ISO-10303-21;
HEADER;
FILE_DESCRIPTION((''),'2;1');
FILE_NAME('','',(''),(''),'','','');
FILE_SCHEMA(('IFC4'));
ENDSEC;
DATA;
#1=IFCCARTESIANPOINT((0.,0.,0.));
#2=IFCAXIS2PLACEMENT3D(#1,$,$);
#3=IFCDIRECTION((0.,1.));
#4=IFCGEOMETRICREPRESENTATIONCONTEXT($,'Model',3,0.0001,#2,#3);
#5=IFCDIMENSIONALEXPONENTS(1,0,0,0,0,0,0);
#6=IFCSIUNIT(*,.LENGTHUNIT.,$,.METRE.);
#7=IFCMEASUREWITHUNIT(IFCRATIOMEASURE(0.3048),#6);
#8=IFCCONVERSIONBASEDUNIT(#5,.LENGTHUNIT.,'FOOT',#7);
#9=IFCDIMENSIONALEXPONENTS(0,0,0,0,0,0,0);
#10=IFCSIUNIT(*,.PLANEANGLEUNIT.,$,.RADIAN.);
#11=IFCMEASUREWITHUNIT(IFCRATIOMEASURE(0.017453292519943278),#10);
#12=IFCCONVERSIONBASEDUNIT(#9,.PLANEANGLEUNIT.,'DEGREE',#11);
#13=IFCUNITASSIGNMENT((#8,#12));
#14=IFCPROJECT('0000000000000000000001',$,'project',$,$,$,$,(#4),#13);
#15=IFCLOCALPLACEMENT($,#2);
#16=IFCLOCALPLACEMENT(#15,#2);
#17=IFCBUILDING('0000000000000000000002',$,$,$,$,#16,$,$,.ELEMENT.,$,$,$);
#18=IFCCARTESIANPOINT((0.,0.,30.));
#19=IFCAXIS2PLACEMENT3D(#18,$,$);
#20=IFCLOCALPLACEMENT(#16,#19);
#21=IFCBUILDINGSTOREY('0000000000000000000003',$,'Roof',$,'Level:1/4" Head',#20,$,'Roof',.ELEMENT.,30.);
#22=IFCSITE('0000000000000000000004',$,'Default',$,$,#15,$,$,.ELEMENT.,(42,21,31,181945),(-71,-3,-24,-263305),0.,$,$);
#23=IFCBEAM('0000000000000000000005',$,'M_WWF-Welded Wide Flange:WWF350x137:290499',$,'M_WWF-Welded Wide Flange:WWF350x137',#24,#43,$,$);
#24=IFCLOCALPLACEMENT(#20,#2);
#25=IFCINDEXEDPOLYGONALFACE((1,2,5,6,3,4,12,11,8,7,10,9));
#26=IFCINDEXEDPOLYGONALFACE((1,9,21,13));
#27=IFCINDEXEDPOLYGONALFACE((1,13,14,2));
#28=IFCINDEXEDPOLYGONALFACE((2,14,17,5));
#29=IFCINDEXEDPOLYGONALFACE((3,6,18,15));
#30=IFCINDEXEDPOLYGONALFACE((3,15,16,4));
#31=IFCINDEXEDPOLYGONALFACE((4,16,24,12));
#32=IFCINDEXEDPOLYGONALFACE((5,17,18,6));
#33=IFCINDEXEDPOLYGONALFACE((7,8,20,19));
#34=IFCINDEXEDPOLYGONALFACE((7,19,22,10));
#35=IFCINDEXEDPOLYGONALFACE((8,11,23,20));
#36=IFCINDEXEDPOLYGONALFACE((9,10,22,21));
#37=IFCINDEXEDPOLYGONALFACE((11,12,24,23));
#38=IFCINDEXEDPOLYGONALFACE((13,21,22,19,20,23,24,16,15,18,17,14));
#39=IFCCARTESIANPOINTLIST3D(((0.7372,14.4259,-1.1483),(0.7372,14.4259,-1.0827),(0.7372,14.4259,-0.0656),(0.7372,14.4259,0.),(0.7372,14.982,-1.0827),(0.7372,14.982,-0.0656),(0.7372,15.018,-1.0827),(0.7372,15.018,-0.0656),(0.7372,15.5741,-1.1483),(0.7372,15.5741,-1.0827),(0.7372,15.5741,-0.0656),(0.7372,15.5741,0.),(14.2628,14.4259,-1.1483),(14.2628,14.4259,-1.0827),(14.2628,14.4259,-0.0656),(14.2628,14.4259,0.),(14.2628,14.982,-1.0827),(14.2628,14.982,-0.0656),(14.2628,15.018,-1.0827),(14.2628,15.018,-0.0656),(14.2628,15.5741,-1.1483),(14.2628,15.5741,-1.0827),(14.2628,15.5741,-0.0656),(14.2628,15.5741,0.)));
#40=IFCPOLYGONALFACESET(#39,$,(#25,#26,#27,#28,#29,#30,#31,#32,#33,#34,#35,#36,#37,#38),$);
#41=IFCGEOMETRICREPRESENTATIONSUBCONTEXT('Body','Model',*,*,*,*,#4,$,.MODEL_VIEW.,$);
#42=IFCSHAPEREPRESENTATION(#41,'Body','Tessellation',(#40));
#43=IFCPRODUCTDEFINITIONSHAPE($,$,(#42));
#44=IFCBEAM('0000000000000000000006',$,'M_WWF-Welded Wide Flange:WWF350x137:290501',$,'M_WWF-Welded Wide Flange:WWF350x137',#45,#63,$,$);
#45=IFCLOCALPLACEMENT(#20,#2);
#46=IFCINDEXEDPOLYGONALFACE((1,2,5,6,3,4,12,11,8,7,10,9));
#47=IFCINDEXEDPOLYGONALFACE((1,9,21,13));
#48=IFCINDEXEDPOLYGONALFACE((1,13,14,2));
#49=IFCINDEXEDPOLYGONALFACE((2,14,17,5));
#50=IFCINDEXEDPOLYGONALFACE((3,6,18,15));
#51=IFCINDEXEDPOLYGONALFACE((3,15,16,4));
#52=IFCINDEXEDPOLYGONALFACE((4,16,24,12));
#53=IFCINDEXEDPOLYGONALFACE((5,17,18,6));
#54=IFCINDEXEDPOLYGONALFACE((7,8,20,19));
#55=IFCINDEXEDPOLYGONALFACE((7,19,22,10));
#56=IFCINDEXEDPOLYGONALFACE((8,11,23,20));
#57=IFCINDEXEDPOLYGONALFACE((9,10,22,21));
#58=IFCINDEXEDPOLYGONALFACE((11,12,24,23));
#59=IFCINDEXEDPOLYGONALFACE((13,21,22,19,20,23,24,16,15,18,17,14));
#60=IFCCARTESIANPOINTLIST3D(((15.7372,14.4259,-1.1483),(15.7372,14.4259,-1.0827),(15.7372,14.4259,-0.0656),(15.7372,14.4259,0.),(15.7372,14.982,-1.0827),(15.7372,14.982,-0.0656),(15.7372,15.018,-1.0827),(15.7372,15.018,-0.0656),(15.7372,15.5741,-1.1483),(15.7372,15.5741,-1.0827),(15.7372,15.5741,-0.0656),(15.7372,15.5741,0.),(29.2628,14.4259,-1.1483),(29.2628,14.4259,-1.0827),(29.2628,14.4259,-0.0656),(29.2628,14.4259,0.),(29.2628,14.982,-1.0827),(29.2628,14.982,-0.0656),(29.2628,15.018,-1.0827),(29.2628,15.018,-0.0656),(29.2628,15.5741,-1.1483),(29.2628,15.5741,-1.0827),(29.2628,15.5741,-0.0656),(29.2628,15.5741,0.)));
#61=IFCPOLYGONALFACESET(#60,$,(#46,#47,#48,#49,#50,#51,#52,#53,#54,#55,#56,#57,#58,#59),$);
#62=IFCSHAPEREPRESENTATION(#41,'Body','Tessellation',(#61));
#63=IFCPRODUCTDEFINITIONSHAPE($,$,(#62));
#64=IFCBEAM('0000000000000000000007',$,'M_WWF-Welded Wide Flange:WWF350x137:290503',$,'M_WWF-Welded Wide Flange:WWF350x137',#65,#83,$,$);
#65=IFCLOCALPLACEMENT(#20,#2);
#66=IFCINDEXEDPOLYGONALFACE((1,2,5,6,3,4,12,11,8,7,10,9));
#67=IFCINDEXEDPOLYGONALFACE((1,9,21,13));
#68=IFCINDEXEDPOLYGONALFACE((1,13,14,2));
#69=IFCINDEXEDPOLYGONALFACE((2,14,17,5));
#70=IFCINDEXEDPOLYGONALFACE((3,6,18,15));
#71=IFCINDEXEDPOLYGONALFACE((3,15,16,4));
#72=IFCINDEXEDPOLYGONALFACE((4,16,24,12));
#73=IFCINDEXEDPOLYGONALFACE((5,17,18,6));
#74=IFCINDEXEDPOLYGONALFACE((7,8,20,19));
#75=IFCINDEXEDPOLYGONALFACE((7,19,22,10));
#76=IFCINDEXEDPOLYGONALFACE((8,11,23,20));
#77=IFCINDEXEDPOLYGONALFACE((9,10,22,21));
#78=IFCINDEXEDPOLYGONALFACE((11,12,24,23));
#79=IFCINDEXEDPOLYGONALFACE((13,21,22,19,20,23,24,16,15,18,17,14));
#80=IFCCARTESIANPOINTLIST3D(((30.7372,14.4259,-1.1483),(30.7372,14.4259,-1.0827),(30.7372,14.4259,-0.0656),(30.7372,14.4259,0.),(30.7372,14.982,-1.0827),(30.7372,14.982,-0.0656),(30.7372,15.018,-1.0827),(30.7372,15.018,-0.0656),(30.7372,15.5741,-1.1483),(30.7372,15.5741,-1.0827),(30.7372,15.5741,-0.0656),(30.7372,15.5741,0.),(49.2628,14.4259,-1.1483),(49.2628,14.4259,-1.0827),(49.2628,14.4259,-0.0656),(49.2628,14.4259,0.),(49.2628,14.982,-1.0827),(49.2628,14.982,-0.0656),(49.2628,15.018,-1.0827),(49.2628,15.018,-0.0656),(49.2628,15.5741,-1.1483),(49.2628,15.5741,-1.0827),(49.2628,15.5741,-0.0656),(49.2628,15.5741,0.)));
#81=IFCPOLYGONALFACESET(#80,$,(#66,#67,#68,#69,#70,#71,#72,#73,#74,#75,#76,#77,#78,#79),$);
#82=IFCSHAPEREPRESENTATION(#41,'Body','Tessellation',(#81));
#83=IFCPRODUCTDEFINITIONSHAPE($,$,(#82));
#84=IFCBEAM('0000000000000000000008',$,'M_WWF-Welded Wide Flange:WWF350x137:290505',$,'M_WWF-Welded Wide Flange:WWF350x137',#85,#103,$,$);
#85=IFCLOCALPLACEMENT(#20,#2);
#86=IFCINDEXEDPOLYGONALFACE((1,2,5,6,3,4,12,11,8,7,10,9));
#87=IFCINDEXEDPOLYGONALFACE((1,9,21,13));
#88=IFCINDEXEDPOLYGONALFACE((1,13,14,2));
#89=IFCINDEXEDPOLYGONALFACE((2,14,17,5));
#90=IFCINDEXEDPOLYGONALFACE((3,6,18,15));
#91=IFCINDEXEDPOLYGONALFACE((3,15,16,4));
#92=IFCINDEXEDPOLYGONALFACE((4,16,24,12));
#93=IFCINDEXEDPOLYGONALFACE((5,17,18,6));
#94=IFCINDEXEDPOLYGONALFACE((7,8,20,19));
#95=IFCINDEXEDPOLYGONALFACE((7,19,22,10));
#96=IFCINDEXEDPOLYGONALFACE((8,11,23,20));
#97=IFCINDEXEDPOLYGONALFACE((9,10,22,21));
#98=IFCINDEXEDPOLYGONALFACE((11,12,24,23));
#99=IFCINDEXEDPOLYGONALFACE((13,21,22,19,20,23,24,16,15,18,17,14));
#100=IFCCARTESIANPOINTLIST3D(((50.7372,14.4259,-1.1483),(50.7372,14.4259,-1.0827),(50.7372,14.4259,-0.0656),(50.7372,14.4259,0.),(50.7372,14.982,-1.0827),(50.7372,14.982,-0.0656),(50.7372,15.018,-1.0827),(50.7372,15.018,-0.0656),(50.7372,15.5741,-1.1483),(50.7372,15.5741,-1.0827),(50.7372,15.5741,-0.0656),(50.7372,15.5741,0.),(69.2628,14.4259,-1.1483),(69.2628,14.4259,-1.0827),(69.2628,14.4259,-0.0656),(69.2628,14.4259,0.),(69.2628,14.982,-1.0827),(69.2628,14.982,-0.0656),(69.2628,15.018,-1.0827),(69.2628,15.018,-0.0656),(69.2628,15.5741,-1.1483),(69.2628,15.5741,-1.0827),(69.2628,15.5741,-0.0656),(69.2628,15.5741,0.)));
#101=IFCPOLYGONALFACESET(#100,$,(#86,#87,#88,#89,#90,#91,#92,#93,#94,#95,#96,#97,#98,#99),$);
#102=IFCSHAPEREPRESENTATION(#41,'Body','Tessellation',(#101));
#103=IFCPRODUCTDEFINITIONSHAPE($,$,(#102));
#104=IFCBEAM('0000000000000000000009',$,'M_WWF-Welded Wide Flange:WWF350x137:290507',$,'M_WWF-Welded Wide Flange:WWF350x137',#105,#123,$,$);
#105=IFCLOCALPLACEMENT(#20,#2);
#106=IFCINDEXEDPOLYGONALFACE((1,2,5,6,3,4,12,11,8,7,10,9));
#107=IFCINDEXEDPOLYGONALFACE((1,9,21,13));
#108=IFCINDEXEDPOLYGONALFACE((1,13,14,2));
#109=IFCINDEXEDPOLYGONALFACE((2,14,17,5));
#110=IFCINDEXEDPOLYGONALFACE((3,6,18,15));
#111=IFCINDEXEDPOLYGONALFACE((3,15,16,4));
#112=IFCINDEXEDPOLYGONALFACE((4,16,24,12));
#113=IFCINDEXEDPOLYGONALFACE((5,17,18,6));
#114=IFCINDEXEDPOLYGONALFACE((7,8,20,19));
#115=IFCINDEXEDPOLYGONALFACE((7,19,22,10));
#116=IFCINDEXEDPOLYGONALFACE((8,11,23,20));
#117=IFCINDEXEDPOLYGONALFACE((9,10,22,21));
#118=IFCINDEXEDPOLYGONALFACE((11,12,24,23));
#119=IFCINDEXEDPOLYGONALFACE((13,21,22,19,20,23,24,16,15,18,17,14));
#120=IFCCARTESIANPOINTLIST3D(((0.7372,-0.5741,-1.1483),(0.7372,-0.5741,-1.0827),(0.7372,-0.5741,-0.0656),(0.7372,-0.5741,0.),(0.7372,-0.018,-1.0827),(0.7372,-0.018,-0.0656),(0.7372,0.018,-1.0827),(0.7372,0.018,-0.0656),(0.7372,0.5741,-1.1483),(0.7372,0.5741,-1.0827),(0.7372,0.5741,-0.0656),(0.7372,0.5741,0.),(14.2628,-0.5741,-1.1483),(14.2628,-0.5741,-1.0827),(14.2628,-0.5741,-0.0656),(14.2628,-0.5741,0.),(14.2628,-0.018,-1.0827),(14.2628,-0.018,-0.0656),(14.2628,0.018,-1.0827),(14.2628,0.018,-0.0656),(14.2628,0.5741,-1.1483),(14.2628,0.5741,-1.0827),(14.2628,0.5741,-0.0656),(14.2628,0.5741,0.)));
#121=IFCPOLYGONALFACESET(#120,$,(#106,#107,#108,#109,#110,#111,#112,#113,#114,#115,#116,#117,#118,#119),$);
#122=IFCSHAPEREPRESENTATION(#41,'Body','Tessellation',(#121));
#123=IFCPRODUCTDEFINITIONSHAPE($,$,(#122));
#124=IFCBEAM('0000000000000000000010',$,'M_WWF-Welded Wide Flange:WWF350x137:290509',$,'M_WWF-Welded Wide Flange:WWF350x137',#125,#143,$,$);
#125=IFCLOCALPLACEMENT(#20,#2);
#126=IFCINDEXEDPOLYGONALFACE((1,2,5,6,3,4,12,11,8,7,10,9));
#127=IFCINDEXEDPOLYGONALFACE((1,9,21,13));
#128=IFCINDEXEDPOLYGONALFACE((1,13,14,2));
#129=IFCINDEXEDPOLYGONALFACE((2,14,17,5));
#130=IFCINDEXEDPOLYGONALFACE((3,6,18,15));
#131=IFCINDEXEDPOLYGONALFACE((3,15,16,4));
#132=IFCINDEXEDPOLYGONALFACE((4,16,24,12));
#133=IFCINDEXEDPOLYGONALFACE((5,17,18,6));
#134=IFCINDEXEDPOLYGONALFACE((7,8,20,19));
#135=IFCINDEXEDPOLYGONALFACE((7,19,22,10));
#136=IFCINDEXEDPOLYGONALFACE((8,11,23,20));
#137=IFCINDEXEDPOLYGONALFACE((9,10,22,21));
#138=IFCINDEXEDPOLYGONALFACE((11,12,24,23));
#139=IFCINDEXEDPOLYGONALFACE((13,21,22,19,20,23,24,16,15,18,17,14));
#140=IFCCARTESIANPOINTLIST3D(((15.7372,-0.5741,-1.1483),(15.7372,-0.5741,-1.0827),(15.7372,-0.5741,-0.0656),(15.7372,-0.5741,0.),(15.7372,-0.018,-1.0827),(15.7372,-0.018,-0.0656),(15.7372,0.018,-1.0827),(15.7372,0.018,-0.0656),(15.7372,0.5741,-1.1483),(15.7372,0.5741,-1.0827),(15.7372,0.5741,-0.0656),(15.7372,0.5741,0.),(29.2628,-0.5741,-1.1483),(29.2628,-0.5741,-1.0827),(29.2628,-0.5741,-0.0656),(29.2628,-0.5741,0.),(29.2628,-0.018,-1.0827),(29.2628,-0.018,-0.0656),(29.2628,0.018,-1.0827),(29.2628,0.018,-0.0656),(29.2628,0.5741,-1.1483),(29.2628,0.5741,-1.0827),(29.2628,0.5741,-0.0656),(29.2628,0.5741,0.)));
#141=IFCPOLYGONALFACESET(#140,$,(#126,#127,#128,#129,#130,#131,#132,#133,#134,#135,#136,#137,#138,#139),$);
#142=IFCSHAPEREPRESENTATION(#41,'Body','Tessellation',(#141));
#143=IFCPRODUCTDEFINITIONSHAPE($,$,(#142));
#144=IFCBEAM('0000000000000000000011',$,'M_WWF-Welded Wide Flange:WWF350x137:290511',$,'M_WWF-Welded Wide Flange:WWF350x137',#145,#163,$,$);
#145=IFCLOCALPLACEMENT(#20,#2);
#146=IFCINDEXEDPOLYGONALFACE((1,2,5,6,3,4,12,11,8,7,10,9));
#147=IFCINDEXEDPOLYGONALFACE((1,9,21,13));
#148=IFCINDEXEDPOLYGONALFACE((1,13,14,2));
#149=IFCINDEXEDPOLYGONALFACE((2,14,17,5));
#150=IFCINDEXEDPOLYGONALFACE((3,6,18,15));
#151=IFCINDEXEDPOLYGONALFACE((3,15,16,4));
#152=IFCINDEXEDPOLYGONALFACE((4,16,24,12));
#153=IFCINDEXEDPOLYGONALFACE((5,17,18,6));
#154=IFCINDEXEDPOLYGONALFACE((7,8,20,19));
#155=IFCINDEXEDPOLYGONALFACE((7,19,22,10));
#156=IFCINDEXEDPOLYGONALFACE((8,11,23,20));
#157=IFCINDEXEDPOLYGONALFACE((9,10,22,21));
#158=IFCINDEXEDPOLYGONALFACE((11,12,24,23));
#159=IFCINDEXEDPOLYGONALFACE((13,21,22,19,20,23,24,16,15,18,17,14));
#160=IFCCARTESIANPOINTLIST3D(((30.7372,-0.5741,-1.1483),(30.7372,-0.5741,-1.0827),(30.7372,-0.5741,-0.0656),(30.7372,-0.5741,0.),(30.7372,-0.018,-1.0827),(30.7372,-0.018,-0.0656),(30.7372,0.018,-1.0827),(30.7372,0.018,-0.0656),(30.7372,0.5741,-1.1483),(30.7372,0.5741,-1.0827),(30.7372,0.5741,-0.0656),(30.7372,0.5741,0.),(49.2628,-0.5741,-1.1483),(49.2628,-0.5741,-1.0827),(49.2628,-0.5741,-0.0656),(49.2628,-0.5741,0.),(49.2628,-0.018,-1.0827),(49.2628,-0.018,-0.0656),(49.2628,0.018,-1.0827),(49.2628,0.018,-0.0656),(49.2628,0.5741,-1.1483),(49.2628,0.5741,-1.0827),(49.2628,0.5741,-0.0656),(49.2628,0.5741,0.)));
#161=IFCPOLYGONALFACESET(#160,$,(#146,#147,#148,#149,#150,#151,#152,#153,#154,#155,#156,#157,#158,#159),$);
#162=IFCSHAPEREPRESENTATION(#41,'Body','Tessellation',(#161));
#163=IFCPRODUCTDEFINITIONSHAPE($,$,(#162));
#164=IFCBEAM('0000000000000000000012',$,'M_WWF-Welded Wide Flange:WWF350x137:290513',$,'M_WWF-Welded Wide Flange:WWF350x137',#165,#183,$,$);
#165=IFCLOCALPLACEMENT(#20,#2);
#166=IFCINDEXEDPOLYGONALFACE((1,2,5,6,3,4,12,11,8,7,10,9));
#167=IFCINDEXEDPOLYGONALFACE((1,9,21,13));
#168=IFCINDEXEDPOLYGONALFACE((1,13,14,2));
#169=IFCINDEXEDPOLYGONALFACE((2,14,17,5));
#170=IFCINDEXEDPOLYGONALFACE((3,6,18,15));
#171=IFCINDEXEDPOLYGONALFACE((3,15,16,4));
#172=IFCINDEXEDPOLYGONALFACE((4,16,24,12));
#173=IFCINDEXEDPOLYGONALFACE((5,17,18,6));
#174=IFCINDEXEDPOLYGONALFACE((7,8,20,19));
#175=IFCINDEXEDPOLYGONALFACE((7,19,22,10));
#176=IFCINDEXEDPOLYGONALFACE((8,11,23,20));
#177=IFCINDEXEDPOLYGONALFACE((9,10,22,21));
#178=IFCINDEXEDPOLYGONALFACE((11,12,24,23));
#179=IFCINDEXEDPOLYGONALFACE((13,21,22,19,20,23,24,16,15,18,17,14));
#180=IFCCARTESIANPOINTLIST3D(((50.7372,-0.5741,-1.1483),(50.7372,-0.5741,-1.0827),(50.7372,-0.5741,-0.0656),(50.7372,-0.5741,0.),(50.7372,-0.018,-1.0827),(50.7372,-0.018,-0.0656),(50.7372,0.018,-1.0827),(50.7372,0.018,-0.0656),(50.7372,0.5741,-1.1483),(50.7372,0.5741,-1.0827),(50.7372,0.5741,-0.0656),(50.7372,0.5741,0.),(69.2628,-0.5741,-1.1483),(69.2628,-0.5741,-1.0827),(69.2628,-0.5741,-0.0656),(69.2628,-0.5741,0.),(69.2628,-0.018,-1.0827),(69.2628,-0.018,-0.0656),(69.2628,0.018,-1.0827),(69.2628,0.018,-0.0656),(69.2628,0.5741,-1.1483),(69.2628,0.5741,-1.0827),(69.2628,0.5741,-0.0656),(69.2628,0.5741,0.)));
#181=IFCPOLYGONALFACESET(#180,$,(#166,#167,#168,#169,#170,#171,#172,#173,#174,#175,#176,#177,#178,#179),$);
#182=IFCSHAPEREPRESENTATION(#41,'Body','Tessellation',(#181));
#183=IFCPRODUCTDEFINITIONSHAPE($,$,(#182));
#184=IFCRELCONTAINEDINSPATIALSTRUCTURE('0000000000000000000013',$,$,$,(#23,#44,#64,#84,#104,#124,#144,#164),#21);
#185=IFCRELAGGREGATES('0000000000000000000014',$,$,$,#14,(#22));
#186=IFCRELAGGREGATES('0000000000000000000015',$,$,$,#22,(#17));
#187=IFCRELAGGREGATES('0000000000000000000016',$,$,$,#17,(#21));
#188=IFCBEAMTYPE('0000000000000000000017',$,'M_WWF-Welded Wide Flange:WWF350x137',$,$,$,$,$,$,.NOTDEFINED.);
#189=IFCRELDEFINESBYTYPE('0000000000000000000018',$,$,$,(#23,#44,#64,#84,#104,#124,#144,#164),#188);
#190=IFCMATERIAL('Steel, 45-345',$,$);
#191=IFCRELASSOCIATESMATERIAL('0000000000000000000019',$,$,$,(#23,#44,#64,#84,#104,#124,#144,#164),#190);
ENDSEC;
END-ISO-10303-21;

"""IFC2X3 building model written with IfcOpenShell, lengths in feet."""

from ifc_helpers import new_model, entity, si_unit, converted_unit, direction, frame, frame_2d, origin, place, context, subcontext, project, spatial, i_section, extrude, material, type_object, element, save


model = new_model("IFC2X3")

# Units and contexts
model_context = context("Model", 3, precision=0.0001, world=origin(), true_north=direction((0.0, 1.0)))
body_context = subcontext(model_context, "Body", "Model", "MODEL_VIEW")
ifc_project = project(units=[converted_unit("LENGTHUNIT", "FOOT", entity("IfcRatioMeasure", 0.3048), si_unit("LENGTHUNIT", "METRE"), dimensions=[1, 0, 0, 0, 0, 0, 0]), converted_unit("PLANEANGLEUNIT", "DEGREE", entity("IfcRatioMeasure", 0.017453292519943278), si_unit("PLANEANGLEUNIT", "RADIAN"), dimensions=[0, 0, 0, 0, 0, 0, 0])], contexts=[model_context])

# Site, building, storey
site_placement = place(None, origin())
site = spatial("IfcSite", under=ifc_project, at=site_placement, Name="Default", CompositionType="ELEMENT", RefLatitude=(42, 21, 31, 181945), RefLongitude=(-71, -3, -24, -263305), RefElevation=0.0)
building_placement = place(site_placement, origin())
building = spatial("IfcBuilding", under=site, at=building_placement, CompositionType="ELEMENT")
storey_placement = place(building_placement, frame((0.0, 0.0, 30.0)))
storey = spatial("IfcBuildingStorey", under=building, at=storey_placement, Name="Roof", ObjectType="Level:1/4\" Head", LongName="Roof", CompositionType="ELEMENT", Elevation=30.0)

# Beams
ifc_material = material(Name="Steel, 45-345")
beam_type = type_object("IfcBeamType", Name="M_WWF-Welded Wide Flange:WWF350x137", PredefinedType="NOTDEFINED")
beam_1_placement = place(storey_placement, frame((0.0, 15.0, 0.0)))
element("IfcBeam", 1, at=beam_1_placement, inside=storey, type_object=beam_type, material=ifc_material, Name="M_WWF-Welded Wide Flange:WWF350x137:290499", ObjectType="M_WWF-Welded Wide Flange:WWF350x137", context=body_context, shape_type="SweptSolid", body=[
    extrude(i_section(OverallWidth=1.1483, OverallDepth=1.1483, WebThickness=0.0361, FlangeThickness=0.0656, at=frame_2d((0.0, 0.0), x_axis=(0.0, 1.0))), frame((0.7372, 0.0, -0.5741), z_axis=(1.0, 0.0, 0.0), x_axis=(0.0, 0.0, -1.0)), (0.0, 0.0, 1.0), 13.5256),
])
beam_2_placement = place(storey_placement, frame((15.0, 15.0, 0.0)))
element("IfcBeam", 2, at=beam_2_placement, inside=storey, type_object=beam_type, material=ifc_material, Name="M_WWF-Welded Wide Flange:WWF350x137:290501", ObjectType="M_WWF-Welded Wide Flange:WWF350x137", context=body_context, shape_type="SweptSolid", body=[
    extrude(i_section(OverallWidth=1.1483, OverallDepth=1.1483, WebThickness=0.0361, FlangeThickness=0.0656, at=frame_2d((0.0, 0.0), x_axis=(0.0, 1.0))), frame((0.7372, 0.0, -0.5741), z_axis=(1.0, 0.0, 0.0), x_axis=(0.0, 0.0, -1.0)), (0.0, 0.0, 1.0), 13.5256),
])
beam_3_placement = place(storey_placement, frame((30.0, 15.0, 0.0)))
element("IfcBeam", 3, at=beam_3_placement, inside=storey, type_object=beam_type, material=ifc_material, Name="M_WWF-Welded Wide Flange:WWF350x137:290503", ObjectType="M_WWF-Welded Wide Flange:WWF350x137", context=body_context, shape_type="SweptSolid", body=[
    extrude(i_section(OverallWidth=1.1483, OverallDepth=1.1483, WebThickness=0.0361, FlangeThickness=0.0656, at=frame_2d((0.0, 0.0), x_axis=(0.0, 1.0))), frame((0.7372, 0.0, -0.5741), z_axis=(1.0, 0.0, 0.0), x_axis=(0.0, 0.0, -1.0)), (0.0, 0.0, 1.0), 18.5256),
])
beam_4_placement = place(storey_placement, frame((50.0, 15.0, 0.0)))
element("IfcBeam", 4, at=beam_4_placement, inside=storey, type_object=beam_type, material=ifc_material, Name="M_WWF-Welded Wide Flange:WWF350x137:290505", ObjectType="M_WWF-Welded Wide Flange:WWF350x137", context=body_context, shape_type="SweptSolid", body=[
    extrude(i_section(OverallWidth=1.1483, OverallDepth=1.1483, WebThickness=0.0361, FlangeThickness=0.0656, at=frame_2d((0.0, 0.0), x_axis=(0.0, 1.0))), frame((0.7372, 0.0, -0.5741), z_axis=(1.0, 0.0, 0.0), x_axis=(0.0, 0.0, -1.0)), (0.0, 0.0, 1.0), 18.5256),
])
beam_5_placement = place(storey_placement, origin())
element("IfcBeam", 5, at=beam_5_placement, inside=storey, type_object=beam_type, material=ifc_material, Name="M_WWF-Welded Wide Flange:WWF350x137:290507", ObjectType="M_WWF-Welded Wide Flange:WWF350x137", context=body_context, shape_type="SweptSolid", body=[
    extrude(i_section(OverallWidth=1.1483, OverallDepth=1.1483, WebThickness=0.0361, FlangeThickness=0.0656, at=frame_2d((0.0, 0.0), x_axis=(0.0, 1.0))), frame((0.7372, 0.0, -0.5741), z_axis=(1.0, 0.0, 0.0), x_axis=(0.0, 0.0, -1.0)), (0.0, 0.0, 1.0), 13.5256),
])
beam_6_placement = place(storey_placement, frame((15.0, 0.0, 0.0)))
element("IfcBeam", 6, at=beam_6_placement, inside=storey, type_object=beam_type, material=ifc_material, Name="M_WWF-Welded Wide Flange:WWF350x137:290509", ObjectType="M_WWF-Welded Wide Flange:WWF350x137", context=body_context, shape_type="SweptSolid", body=[
    extrude(i_section(OverallWidth=1.1483, OverallDepth=1.1483, WebThickness=0.0361, FlangeThickness=0.0656, at=frame_2d((0.0, 0.0), x_axis=(0.0, 1.0))), frame((0.7372, 0.0, -0.5741), z_axis=(1.0, 0.0, 0.0), x_axis=(0.0, 0.0, -1.0)), (0.0, 0.0, 1.0), 13.5256),
])
beam_7_placement = place(storey_placement, frame((30.0, 0.0, 0.0)))
element("IfcBeam", 7, at=beam_7_placement, inside=storey, type_object=beam_type, material=ifc_material, Name="M_WWF-Welded Wide Flange:WWF350x137:290511", ObjectType="M_WWF-Welded Wide Flange:WWF350x137", context=body_context, shape_type="SweptSolid", body=[
    extrude(i_section(OverallWidth=1.1483, OverallDepth=1.1483, WebThickness=0.0361, FlangeThickness=0.0656, at=frame_2d((0.0, 0.0), x_axis=(0.0, 1.0))), frame((0.7372, 0.0, -0.5741), z_axis=(1.0, 0.0, 0.0), x_axis=(0.0, 0.0, -1.0)), (0.0, 0.0, 1.0), 18.5256),
])
beam_8_placement = place(storey_placement, frame((50.0, 0.0, 0.0)))
element("IfcBeam", 8, at=beam_8_placement, inside=storey, type_object=beam_type, material=ifc_material, Name="M_WWF-Welded Wide Flange:WWF350x137:290513", ObjectType="M_WWF-Welded Wide Flange:WWF350x137", context=body_context, shape_type="SweptSolid", body=[
    extrude(i_section(OverallWidth=1.1483, OverallDepth=1.1483, WebThickness=0.0361, FlangeThickness=0.0656, at=frame_2d((0.0, 0.0), x_axis=(0.0, 1.0))), frame((0.7372, 0.0, -0.5741), z_axis=(1.0, 0.0, 0.0), x_axis=(0.0, 0.0, -1.0)), (0.0, 0.0, 1.0), 18.5256),
])

save(model, "model.ifc")
